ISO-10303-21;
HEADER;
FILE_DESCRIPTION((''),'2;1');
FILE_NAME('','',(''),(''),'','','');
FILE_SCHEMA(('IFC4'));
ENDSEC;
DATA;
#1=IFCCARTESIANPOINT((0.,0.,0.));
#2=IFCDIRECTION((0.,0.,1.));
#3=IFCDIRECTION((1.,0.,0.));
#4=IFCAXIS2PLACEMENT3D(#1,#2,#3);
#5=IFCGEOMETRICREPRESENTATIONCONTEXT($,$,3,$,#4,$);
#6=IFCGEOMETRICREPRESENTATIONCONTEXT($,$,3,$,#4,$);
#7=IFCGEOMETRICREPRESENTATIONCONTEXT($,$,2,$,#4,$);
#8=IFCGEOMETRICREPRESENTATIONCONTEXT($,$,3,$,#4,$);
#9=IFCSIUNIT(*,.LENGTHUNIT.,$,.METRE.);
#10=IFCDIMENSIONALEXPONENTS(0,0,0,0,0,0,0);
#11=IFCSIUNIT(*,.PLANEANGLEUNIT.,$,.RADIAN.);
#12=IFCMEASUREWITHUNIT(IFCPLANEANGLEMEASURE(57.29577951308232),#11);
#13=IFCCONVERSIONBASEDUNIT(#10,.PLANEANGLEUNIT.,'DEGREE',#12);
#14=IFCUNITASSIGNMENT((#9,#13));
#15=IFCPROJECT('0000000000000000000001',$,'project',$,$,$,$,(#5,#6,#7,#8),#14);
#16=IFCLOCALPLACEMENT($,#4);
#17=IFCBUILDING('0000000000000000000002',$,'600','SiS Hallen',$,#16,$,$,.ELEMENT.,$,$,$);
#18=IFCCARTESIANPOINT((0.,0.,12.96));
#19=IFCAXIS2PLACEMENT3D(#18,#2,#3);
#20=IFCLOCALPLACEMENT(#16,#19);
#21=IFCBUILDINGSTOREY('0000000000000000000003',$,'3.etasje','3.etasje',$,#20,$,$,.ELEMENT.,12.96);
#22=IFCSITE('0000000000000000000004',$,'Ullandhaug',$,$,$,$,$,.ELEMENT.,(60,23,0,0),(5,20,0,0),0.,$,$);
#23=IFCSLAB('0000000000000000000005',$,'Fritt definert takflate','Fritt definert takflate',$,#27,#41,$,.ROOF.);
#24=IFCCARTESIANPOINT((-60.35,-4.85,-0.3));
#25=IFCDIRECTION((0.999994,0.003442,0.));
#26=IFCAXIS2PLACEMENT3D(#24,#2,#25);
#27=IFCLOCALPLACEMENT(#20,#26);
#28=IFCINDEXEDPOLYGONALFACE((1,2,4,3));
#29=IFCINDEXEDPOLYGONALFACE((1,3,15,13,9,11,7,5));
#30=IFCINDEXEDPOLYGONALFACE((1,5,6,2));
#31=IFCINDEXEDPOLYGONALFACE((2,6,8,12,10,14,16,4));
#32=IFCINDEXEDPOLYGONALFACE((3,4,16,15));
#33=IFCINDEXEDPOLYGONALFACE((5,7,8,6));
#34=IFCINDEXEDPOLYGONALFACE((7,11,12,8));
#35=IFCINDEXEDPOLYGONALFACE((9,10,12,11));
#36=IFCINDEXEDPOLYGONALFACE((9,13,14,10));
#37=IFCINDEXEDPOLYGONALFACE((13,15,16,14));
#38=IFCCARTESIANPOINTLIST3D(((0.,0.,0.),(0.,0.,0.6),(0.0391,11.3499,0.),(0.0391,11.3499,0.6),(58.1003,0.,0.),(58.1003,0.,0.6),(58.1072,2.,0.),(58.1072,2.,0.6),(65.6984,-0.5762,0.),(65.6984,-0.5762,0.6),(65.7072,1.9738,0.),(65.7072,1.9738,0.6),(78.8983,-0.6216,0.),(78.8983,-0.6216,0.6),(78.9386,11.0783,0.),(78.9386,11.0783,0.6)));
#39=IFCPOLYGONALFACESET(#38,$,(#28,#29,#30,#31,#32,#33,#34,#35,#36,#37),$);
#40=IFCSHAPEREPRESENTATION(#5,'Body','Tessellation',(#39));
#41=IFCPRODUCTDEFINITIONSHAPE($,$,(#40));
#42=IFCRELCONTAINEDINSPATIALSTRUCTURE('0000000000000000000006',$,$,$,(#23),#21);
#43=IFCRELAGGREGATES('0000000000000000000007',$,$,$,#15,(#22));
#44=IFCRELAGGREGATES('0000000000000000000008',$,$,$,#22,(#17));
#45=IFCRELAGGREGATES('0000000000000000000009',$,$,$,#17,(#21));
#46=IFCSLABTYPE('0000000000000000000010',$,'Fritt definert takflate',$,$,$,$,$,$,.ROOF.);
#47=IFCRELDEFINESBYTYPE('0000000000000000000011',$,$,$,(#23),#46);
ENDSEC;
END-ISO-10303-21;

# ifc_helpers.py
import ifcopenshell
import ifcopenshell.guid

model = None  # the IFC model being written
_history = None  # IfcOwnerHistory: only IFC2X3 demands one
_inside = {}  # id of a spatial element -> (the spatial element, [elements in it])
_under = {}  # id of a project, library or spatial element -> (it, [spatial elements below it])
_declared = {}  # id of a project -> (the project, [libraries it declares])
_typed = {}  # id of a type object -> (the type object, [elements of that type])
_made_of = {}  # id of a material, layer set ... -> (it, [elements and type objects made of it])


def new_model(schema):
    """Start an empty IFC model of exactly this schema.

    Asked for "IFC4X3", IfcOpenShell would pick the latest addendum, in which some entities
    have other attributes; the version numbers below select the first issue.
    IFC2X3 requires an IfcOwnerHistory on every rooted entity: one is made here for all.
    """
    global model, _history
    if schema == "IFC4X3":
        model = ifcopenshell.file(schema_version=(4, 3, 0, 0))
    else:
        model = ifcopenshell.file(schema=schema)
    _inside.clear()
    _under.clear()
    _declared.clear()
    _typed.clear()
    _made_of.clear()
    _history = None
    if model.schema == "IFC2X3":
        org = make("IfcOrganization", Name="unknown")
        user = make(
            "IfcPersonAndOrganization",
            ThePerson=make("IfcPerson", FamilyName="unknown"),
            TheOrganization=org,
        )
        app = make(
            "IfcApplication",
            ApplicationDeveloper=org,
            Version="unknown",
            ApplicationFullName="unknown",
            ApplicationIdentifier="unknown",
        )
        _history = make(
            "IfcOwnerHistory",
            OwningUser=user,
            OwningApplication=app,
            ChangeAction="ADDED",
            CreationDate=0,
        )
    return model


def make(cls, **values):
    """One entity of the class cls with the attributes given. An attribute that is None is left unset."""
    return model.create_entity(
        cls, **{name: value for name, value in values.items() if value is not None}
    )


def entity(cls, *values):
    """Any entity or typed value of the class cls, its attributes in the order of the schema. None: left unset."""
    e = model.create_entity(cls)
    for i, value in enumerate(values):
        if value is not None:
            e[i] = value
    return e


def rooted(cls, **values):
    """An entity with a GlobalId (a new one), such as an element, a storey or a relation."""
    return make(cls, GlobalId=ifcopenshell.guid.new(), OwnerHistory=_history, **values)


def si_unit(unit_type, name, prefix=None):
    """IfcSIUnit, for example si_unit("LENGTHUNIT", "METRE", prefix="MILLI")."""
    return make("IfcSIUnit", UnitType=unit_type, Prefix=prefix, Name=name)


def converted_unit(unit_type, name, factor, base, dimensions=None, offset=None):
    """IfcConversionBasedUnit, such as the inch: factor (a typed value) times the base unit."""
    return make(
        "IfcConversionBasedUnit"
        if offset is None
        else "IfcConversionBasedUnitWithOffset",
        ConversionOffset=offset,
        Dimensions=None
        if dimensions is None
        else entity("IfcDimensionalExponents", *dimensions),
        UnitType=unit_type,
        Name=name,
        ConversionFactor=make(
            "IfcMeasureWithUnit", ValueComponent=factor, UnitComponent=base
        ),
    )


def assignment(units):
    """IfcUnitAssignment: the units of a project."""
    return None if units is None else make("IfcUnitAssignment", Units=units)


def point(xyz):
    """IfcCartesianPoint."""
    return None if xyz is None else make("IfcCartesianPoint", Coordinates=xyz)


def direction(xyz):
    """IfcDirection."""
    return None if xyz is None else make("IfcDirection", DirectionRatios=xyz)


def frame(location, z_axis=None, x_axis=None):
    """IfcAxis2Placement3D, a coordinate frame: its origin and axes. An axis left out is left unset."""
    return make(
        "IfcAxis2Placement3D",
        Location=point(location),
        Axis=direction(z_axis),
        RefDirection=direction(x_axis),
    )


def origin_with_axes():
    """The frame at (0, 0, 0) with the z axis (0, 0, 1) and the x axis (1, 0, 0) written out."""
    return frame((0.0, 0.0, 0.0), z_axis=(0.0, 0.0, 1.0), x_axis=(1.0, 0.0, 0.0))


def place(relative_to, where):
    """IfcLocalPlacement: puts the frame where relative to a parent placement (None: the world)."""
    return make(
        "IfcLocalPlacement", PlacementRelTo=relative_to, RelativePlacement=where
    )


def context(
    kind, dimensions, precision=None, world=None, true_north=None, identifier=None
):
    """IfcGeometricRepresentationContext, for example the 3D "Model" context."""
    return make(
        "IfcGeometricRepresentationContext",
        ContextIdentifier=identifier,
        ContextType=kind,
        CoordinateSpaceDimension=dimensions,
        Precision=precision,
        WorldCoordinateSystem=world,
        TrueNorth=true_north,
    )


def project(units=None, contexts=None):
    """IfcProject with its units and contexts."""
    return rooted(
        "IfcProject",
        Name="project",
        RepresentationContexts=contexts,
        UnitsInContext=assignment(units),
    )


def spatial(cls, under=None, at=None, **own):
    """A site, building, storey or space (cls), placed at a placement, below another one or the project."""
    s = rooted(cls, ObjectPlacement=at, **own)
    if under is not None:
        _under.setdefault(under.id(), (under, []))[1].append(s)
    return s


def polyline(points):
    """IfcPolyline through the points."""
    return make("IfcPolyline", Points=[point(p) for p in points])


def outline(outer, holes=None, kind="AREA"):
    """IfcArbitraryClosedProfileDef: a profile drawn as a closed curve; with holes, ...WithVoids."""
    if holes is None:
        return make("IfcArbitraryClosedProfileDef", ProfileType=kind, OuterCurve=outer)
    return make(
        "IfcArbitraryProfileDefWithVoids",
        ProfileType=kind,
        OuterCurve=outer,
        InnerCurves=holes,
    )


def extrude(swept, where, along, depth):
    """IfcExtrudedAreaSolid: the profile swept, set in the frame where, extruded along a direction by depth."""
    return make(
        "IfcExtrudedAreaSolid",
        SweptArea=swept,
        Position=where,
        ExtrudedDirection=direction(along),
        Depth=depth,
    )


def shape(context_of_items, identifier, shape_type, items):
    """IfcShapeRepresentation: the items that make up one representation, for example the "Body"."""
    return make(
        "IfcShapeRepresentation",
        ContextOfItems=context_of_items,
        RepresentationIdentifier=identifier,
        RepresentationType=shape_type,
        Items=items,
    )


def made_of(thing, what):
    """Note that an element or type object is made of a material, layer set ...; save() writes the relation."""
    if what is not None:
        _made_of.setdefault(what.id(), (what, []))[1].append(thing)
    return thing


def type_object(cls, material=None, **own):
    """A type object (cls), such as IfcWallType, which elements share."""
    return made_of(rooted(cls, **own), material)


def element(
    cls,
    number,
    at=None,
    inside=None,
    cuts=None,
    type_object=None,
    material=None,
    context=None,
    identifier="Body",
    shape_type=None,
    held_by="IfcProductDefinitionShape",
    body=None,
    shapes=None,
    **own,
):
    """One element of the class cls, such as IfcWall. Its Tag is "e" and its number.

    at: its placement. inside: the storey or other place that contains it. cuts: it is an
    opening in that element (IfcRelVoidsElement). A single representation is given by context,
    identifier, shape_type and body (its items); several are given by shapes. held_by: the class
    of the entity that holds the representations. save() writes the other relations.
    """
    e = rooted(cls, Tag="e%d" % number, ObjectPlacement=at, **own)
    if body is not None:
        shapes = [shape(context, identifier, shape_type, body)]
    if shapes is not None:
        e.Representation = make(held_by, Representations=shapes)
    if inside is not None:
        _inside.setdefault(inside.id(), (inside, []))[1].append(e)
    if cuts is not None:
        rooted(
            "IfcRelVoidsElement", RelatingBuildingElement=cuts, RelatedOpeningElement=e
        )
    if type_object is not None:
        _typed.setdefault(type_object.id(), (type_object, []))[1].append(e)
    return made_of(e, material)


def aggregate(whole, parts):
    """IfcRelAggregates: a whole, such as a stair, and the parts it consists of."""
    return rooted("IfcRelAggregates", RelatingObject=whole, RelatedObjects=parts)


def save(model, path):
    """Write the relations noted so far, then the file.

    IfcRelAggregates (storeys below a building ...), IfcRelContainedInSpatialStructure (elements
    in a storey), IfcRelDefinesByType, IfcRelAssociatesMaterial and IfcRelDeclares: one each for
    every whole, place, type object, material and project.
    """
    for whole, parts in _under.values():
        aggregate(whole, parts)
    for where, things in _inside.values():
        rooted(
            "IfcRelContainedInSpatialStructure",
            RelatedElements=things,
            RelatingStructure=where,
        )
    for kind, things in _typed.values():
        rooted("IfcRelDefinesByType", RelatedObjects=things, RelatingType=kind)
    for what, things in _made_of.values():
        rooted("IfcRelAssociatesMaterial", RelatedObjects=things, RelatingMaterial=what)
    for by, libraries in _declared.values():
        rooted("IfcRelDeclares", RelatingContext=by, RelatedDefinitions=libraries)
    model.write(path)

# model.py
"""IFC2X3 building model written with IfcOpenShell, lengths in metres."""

from ifc_helpers import new_model, entity, si_unit, converted_unit, frame, origin_with_axes, place, context, project, spatial, polyline, outline, extrude, type_object, element, save


model = new_model("IFC2X3")

# Units and contexts
context_of_model_1 = context(None, 3, world=origin_with_axes())
context_of_model_2 = context(None, 3, world=origin_with_axes())
context_of_model_3 = context(None, 2, world=origin_with_axes())
context_of_model_4 = context(None, 3, world=origin_with_axes())
ifc_project = project(units=[si_unit("LENGTHUNIT", "METRE"), converted_unit("PLANEANGLEUNIT", "DEGREE", entity("IfcPlaneAngleMeasure", 57.29577951308232), si_unit("PLANEANGLEUNIT", "RADIAN"), dimensions=[0, 0, 0, 0, 0, 0, 0])], contexts=[context_of_model_1, context_of_model_2, context_of_model_3, context_of_model_4])

# Site, building, storey
site = spatial("IfcSite", under=ifc_project, Name="Ullandhaug", CompositionType="ELEMENT", RefLatitude=(60, 23, 0, 0), RefLongitude=(5, 20, 0, 0), RefElevation=0.0)
building_placement = place(None, origin_with_axes())
building = spatial("IfcBuilding", under=site, at=building_placement, Name="600", Description="SiS Hallen", CompositionType="ELEMENT")
storey_placement = place(building_placement, frame((0.0, 0.0, 12.96), z_axis=(0.0, 0.0, 1.0), x_axis=(1.0, 0.0, 0.0)))
storey = spatial("IfcBuildingStorey", under=building, at=storey_placement, Name="3.etasje", Description="3.etasje", CompositionType="ELEMENT", Elevation=12.96)

# Slab
slab_type_1 = type_object("IfcSlabType", Name="Fritt definert takflate", PredefinedType="ROOF")
slab_1_placement = place(storey_placement, frame((-60.35, -4.85, -0.3), z_axis=(0.0, 0.0, 1.0), x_axis=(0.999994, 0.003442, 0.0)))
element("IfcSlab", 1, at=slab_1_placement, inside=storey, type_object=slab_type_1, Name="Fritt definert takflate", Description="Fritt definert takflate", PredefinedType="ROOF", context=context_of_model_1, shape_type="SweptSolid", body=[
    extrude(outline(polyline([(0.0, 0.0), (58.1003, 0.0), (58.1072, 2.0), (65.7072, 1.9738), (65.6984, -0.5762), (78.8983, -0.6216), (78.9386, 11.0783), (0.0391, 11.3499), (0.0, 0.0)])), origin_with_axes(), (0.0, 0.0, 1.0), 0.6),
])

save(model, "model.ifc")
